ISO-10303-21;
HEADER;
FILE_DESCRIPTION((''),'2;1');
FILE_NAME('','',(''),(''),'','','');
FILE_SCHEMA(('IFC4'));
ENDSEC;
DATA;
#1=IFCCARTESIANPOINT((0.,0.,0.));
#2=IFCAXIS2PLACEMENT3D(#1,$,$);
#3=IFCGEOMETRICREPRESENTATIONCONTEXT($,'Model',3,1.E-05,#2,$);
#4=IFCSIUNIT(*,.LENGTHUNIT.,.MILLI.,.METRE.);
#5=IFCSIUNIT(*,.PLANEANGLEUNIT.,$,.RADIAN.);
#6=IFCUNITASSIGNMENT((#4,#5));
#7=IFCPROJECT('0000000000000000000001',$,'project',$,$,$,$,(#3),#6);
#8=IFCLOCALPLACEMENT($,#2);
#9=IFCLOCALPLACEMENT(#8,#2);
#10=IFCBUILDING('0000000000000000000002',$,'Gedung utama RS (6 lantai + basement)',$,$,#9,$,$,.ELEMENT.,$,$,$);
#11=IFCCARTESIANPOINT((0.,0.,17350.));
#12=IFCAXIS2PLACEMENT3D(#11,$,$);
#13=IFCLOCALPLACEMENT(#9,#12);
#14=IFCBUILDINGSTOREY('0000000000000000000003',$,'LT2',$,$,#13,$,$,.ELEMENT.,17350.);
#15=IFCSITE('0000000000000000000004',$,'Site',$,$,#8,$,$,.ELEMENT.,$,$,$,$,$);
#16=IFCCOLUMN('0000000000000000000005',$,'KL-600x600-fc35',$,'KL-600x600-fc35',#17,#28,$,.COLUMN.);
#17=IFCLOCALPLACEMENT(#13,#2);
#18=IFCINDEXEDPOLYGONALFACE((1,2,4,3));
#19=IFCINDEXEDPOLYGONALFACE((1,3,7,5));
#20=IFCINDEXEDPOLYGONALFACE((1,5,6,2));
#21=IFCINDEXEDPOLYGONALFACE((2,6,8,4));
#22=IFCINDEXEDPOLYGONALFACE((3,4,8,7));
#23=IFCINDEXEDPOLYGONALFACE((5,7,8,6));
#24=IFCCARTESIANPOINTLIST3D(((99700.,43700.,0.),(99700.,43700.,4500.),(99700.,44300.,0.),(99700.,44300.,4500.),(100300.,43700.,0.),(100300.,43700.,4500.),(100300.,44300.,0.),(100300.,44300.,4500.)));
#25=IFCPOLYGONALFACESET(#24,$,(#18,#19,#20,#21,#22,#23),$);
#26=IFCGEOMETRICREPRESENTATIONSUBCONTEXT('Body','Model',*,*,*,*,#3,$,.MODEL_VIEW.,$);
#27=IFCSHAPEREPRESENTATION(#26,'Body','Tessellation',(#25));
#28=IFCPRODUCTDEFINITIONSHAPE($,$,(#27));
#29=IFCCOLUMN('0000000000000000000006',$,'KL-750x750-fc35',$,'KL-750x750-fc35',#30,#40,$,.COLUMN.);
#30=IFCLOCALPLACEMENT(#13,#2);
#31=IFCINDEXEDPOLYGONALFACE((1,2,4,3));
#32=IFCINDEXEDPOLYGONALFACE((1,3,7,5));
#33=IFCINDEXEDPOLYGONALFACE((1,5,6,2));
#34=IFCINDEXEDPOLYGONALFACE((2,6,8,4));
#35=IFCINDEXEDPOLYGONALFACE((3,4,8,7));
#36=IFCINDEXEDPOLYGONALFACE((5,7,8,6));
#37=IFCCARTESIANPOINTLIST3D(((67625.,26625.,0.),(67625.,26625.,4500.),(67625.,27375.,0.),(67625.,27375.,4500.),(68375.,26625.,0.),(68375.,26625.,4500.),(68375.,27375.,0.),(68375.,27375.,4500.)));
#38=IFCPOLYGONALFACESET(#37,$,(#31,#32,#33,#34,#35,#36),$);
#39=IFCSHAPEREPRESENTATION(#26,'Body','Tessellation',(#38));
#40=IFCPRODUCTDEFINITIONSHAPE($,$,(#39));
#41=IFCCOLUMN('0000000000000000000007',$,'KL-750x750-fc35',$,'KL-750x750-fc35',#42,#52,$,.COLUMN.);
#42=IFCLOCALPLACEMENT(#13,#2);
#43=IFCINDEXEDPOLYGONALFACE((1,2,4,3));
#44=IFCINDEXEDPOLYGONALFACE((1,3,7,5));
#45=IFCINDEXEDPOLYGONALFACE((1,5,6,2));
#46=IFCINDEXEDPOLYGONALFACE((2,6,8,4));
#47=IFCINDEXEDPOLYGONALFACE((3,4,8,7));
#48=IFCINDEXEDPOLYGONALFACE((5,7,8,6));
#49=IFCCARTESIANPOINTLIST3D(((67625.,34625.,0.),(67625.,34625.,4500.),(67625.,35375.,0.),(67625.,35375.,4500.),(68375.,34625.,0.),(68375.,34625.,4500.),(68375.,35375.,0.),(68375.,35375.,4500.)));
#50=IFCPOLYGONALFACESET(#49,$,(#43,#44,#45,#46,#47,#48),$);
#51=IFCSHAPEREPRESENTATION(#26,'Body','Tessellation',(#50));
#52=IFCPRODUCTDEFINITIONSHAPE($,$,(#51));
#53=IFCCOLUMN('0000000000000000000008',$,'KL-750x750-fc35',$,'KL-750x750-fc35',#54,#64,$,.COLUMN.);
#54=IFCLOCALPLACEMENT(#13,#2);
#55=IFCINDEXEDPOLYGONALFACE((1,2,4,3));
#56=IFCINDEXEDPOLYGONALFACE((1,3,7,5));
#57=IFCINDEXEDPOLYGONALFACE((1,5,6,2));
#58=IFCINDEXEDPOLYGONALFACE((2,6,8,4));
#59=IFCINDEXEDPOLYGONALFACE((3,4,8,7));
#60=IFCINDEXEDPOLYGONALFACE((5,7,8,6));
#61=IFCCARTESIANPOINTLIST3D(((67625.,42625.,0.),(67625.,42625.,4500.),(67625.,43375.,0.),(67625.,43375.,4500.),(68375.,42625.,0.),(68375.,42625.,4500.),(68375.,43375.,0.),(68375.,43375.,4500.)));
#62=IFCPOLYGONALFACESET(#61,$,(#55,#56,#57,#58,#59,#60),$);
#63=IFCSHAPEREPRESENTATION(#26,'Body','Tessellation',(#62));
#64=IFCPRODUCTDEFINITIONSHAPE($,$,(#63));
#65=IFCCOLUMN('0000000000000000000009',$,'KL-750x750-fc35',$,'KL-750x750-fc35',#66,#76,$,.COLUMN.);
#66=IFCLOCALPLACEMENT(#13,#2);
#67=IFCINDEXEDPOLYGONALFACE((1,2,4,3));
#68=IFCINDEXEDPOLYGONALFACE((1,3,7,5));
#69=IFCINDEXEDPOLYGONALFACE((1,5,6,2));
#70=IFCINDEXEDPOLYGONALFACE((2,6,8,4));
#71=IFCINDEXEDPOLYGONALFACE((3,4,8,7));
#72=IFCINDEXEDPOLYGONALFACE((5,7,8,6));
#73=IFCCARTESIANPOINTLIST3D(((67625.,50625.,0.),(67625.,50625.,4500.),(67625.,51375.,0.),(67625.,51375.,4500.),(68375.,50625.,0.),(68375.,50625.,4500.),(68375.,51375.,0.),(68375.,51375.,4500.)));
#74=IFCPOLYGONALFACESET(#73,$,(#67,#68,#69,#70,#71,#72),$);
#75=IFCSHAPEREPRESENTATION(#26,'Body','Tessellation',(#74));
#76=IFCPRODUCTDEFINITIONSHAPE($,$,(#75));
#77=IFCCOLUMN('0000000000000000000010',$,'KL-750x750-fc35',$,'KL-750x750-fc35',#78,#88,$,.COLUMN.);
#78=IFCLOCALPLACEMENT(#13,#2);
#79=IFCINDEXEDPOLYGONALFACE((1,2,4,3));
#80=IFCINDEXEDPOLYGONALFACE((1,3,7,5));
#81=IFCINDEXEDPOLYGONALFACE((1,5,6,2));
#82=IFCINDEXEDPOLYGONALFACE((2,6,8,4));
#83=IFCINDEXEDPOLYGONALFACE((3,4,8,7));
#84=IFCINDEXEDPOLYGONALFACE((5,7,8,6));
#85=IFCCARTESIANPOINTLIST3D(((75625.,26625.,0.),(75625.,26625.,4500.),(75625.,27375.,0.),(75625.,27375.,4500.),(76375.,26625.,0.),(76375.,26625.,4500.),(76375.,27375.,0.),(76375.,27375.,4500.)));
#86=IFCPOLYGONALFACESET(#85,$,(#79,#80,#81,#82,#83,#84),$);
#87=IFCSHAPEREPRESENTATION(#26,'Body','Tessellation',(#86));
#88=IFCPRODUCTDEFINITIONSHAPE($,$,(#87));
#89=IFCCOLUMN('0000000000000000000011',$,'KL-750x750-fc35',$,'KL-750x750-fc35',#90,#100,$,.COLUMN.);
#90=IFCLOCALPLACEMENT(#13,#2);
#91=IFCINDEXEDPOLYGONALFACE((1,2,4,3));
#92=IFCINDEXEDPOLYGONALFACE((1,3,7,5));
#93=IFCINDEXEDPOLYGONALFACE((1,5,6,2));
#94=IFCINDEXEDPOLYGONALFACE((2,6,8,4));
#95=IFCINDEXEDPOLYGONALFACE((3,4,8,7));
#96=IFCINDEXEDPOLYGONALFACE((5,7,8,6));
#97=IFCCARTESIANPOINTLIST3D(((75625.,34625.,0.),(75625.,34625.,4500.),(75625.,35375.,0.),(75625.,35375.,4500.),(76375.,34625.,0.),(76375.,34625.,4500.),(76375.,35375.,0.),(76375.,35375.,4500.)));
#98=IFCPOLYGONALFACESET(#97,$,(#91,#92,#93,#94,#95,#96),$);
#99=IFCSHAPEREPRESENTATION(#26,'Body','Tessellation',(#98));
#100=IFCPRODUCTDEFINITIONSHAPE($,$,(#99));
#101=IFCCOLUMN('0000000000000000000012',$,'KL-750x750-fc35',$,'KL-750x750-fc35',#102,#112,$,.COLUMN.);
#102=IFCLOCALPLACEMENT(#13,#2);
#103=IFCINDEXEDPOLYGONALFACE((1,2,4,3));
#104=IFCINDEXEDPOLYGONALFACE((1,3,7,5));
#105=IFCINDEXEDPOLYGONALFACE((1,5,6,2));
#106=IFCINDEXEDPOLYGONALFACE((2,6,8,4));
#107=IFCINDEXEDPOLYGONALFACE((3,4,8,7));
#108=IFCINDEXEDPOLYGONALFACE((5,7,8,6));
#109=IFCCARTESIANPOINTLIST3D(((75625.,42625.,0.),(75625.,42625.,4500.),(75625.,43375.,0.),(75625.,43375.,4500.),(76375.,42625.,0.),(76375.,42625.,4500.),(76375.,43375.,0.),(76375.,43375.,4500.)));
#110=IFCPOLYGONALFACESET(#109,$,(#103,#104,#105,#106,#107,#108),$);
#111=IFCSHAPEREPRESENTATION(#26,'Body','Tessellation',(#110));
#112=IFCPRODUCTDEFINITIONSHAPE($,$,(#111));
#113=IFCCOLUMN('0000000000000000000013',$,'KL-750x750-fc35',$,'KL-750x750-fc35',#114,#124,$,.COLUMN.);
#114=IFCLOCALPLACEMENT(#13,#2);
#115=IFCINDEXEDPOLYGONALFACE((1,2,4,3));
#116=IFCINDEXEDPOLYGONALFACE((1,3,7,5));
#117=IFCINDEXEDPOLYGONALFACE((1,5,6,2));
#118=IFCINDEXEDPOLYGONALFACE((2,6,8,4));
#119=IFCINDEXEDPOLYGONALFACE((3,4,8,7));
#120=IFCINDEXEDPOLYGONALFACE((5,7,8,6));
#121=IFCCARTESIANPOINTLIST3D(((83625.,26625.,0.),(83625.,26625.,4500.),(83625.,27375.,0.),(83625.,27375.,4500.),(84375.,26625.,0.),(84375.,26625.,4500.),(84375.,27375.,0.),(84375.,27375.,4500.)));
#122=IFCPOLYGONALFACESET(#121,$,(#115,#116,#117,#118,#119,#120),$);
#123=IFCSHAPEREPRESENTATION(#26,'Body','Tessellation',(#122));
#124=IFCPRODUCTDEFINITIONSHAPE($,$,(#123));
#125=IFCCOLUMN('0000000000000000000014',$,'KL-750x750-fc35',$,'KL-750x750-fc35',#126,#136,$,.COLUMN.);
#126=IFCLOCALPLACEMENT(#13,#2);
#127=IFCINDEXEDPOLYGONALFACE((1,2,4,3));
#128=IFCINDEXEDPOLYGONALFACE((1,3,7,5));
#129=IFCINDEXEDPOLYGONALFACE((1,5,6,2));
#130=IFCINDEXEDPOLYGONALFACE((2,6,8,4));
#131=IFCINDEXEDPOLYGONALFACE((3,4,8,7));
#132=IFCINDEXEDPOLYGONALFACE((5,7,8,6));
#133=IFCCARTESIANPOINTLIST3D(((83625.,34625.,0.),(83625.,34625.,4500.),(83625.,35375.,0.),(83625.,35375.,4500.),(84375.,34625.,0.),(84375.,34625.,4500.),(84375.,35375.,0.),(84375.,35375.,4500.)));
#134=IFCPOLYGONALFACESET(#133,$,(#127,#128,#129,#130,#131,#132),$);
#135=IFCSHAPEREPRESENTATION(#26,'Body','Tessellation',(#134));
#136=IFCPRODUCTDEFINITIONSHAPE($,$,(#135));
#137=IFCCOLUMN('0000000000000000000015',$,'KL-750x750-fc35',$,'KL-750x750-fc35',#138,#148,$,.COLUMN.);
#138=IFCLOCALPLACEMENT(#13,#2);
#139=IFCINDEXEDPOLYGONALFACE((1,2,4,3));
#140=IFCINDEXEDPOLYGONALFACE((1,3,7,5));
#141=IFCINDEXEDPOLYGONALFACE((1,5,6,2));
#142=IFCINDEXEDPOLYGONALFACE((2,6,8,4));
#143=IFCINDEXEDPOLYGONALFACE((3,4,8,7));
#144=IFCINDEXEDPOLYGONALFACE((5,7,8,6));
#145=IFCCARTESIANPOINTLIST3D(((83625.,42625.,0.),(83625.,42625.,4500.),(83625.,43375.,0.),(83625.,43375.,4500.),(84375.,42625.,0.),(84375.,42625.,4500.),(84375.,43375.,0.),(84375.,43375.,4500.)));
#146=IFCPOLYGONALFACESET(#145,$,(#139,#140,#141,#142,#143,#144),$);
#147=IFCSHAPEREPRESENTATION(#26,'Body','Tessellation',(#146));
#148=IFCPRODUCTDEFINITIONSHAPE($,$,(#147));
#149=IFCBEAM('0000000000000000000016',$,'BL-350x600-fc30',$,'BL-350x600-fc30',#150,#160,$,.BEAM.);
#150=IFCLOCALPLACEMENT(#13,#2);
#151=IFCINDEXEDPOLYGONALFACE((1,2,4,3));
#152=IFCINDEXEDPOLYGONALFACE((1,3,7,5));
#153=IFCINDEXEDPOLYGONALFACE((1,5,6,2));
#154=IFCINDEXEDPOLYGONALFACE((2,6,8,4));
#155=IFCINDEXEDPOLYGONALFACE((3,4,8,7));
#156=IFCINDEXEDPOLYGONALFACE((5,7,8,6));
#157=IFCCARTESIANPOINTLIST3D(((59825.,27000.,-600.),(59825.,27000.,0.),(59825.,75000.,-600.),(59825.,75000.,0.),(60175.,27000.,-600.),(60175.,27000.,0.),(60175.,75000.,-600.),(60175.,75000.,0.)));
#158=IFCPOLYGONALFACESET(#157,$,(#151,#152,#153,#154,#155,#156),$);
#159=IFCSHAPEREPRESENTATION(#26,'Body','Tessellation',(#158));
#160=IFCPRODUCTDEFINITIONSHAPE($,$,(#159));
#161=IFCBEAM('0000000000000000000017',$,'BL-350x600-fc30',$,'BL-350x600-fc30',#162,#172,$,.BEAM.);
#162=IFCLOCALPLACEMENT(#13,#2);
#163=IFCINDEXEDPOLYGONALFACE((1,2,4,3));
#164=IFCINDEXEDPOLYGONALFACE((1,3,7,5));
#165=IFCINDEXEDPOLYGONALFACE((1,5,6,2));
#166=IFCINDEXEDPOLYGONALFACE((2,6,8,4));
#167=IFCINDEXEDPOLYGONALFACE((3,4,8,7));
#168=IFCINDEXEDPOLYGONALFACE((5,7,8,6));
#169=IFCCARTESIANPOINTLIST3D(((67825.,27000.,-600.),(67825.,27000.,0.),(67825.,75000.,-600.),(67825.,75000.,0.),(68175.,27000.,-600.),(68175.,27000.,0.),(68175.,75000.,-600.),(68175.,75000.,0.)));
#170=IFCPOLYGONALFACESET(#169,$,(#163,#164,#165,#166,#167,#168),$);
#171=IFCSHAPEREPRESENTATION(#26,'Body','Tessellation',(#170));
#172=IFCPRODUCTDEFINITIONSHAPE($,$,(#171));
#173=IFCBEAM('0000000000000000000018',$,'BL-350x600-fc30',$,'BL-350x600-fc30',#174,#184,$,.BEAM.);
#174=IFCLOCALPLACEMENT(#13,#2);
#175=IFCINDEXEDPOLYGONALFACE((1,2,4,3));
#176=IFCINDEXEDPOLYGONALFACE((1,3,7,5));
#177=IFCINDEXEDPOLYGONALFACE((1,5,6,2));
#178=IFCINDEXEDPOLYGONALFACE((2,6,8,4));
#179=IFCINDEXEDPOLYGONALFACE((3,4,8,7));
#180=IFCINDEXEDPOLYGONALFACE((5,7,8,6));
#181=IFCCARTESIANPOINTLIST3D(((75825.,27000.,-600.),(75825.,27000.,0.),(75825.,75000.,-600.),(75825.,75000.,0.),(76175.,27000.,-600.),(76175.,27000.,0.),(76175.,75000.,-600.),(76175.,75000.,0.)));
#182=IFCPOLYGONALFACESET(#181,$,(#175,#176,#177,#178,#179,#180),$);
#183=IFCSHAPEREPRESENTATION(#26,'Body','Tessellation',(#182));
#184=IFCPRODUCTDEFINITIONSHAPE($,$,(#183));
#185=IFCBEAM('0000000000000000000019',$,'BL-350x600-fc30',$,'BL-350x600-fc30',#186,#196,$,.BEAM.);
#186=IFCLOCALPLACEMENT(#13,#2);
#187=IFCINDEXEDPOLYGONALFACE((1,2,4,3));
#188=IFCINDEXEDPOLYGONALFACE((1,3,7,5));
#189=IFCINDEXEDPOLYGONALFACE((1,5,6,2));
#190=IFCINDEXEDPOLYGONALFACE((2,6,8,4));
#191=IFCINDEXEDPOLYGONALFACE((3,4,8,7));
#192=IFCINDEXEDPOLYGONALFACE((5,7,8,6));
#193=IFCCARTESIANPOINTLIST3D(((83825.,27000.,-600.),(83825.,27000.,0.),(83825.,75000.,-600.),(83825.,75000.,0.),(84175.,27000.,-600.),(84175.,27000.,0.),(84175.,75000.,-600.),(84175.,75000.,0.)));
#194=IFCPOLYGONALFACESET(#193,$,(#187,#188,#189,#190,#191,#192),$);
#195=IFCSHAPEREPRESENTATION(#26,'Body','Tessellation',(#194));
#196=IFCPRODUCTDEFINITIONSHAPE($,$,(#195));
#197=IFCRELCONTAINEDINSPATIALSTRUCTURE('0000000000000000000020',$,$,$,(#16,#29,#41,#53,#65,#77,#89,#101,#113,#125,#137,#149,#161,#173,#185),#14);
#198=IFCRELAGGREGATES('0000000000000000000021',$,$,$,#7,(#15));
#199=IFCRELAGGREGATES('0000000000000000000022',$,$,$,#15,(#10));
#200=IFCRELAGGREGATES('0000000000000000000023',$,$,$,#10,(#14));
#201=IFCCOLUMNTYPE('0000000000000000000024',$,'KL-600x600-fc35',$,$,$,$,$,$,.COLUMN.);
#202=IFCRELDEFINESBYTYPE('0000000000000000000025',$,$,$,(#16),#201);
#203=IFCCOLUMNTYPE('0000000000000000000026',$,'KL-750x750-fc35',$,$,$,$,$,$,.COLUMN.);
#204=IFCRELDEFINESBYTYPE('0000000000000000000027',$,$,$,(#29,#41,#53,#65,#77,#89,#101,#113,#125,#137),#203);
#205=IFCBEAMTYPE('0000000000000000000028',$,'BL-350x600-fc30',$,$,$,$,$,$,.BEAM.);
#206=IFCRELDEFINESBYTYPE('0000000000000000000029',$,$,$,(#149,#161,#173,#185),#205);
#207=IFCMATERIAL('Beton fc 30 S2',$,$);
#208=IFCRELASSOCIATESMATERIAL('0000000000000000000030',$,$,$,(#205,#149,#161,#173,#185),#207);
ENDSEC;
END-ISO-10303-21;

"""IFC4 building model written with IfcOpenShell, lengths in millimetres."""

from ifc_helpers import new_model, si_unit, frame, origin, origin_2d, place, context, subcontext, project, spatial, rectangle, extrude, material, material_profile, profile_set, profile_usage, type_object, element, save


model = new_model("IFC4")

# Units and contexts
model_context = context("Model", 3, precision=1e-05, world=origin())
body_context = subcontext(model_context, "Body", "Model", "MODEL_VIEW")
ifc_project = project(units=[si_unit("LENGTHUNIT", "METRE", prefix="MILLI"), si_unit("PLANEANGLEUNIT", "RADIAN")], contexts=[model_context])

# Site, building, storey
site_placement = place(None, origin())
site = spatial("IfcSite", under=ifc_project, at=site_placement, Name="Site", CompositionType="ELEMENT")
building_placement = place(site_placement, origin())
building = spatial("IfcBuilding", under=site, at=building_placement, Name="Gedung utama RS (6 lantai + basement)", CompositionType="ELEMENT")
storey_placement = place(building_placement, frame((0.0, 0.0, 17350.0)))
storey = spatial("IfcBuildingStorey", under=building, at=storey_placement, Name="LT2", CompositionType="ELEMENT", Elevation=17350.0)

# Columns
ifc_material_profile_1 = material_profile(None, rectangle(XDim=600.0, YDim=600.0, at=origin_2d()), Name="KL-600x600-fc35")
ifc_profile_set_1 = profile_set([ifc_material_profile_1], Name="KL-600x600-fc35")
ifc_profile_usage_1 = profile_usage(ifc_profile_set_1, cardinal=5)
column_type_1 = type_object("IfcColumnType", Name="KL-600x600-fc35", PredefinedType="COLUMN", material=ifc_profile_set_1)
column_placement = place(storey_placement, frame((100000.0, 44000.0, 0.0), z_axis=(0.0, 0.0, 1.0), x_axis=(1.0, 0.0, 0.0)))
element("IfcColumn", 1, at=column_placement, inside=storey, type_object=column_type_1, material=ifc_profile_usage_1, Name="KL-600x600-fc35", ObjectType="KL-600x600-fc35", PredefinedType="COLUMN", context=body_context, shape_type="SweptSolid", body=[
    extrude(rectangle(XDim=600.0, YDim=600.0, at=origin_2d()), origin(), (0.0, 0.0, 1.0), 4500.0),
])
ifc_material_profile_2 = material_profile(None, rectangle(XDim=750.0, YDim=750.0, at=origin_2d()), Name="KL-750x750-fc35")
ifc_profile_set_2 = profile_set([ifc_material_profile_2], Name="KL-750x750-fc35")
ifc_profile_usage_2 = profile_usage(ifc_profile_set_2, cardinal=5)
column_type_2 = type_object("IfcColumnType", Name="KL-750x750-fc35", PredefinedType="COLUMN", material=ifc_profile_set_2)
for number, where, z_axis, x_axis, name in (
    (2, (68000.0, 27000.0, 0.0), (0.0, 0.0, 1.0), (1.0, 0.0, 0.0), "KL-750x750-fc35"),
    (3, (68000.0, 35000.0, 0.0), (0.0, 0.0, 1.0), (1.0, 0.0, 0.0), "KL-750x750-fc35"),
    (4, (68000.0, 43000.0, 0.0), (0.0, 0.0, 1.0), (1.0, 0.0, 0.0), "KL-750x750-fc35"),
    (5, (68000.0, 51000.0, 0.0), (0.0, 0.0, 1.0), (1.0, 0.0, 0.0), "KL-750x750-fc35"),
    (6, (76000.0, 27000.0, 0.0), (0.0, 0.0, 1.0), (1.0, 0.0, 0.0), "KL-750x750-fc35"),
    (7, (76000.0, 35000.0, 0.0), (0.0, 0.0, 1.0), (1.0, 0.0, 0.0), "KL-750x750-fc35"),
    (8, (76000.0, 43000.0, 0.0), (0.0, 0.0, 1.0), (1.0, 0.0, 0.0), "KL-750x750-fc35"),
    (9, (84000.0, 27000.0, 0.0), (0.0, 0.0, 1.0), (1.0, 0.0, 0.0), "KL-750x750-fc35"),
    (10, (84000.0, 35000.0, 0.0), (0.0, 0.0, 1.0), (1.0, 0.0, 0.0), "KL-750x750-fc35"),
    (11, (84000.0, 43000.0, 0.0), (0.0, 0.0, 1.0), (1.0, 0.0, 0.0), "KL-750x750-fc35"),
):
    element("IfcColumn", number, at=place(storey_placement, frame(where, z_axis=z_axis, x_axis=x_axis)), inside=storey, type_object=column_type_2, material=ifc_profile_usage_2, Name=name, ObjectType="KL-750x750-fc35", PredefinedType="COLUMN", context=body_context, shape_type="SweptSolid", body=[
        extrude(rectangle(XDim=750.0, YDim=750.0, at=origin_2d()), origin(), (0.0, 0.0, 1.0), 4500.0),
    ])

# Beams
ifc_material_1 = material(Name="Beton fc 30 S2")
ifc_material_profile_3 = material_profile(ifc_material_1, rectangle(XDim=350.0, YDim=600.0, at=origin_2d()), Name="BL-350x600-fc30")
ifc_profile_set_3 = profile_set([ifc_material_profile_3], Name="BL-350x600-fc30")
ifc_profile_usage_3 = profile_usage(ifc_profile_set_3, cardinal=8)
beam_type = type_object("IfcBeamType", Name="BL-350x600-fc30", PredefinedType="BEAM", material=ifc_profile_set_3)
for number, where, name in (
    (12, (60000.0, 27000.0, -300.0), "BL-350x600-fc30"),
    (13, (68000.0, 27000.0, -300.0), "BL-350x600-fc30"),
    (14, (76000.0, 27000.0, -300.0), "BL-350x600-fc30"),
    (15, (84000.0, 27000.0, -300.0), "BL-350x600-fc30"),
):
    element("IfcBeam", number, at=place(storey_placement, frame(where)), inside=storey, type_object=beam_type, material=ifc_profile_usage_3, Name=name, ObjectType="BL-350x600-fc30", PredefinedType="BEAM", context=body_context, shape_type="SweptSolid", body=[
        extrude(rectangle(XDim=350.0, YDim=600.0, at=origin_2d()), frame((0.0, 0.0, 0.0), z_axis=(0.0, 1.0, 0.0), x_axis=(-1.0, 0.0, 0.0)), (0.0, 0.0, 1.0), 48000.0),
    ])

save(model, "model.ifc")
